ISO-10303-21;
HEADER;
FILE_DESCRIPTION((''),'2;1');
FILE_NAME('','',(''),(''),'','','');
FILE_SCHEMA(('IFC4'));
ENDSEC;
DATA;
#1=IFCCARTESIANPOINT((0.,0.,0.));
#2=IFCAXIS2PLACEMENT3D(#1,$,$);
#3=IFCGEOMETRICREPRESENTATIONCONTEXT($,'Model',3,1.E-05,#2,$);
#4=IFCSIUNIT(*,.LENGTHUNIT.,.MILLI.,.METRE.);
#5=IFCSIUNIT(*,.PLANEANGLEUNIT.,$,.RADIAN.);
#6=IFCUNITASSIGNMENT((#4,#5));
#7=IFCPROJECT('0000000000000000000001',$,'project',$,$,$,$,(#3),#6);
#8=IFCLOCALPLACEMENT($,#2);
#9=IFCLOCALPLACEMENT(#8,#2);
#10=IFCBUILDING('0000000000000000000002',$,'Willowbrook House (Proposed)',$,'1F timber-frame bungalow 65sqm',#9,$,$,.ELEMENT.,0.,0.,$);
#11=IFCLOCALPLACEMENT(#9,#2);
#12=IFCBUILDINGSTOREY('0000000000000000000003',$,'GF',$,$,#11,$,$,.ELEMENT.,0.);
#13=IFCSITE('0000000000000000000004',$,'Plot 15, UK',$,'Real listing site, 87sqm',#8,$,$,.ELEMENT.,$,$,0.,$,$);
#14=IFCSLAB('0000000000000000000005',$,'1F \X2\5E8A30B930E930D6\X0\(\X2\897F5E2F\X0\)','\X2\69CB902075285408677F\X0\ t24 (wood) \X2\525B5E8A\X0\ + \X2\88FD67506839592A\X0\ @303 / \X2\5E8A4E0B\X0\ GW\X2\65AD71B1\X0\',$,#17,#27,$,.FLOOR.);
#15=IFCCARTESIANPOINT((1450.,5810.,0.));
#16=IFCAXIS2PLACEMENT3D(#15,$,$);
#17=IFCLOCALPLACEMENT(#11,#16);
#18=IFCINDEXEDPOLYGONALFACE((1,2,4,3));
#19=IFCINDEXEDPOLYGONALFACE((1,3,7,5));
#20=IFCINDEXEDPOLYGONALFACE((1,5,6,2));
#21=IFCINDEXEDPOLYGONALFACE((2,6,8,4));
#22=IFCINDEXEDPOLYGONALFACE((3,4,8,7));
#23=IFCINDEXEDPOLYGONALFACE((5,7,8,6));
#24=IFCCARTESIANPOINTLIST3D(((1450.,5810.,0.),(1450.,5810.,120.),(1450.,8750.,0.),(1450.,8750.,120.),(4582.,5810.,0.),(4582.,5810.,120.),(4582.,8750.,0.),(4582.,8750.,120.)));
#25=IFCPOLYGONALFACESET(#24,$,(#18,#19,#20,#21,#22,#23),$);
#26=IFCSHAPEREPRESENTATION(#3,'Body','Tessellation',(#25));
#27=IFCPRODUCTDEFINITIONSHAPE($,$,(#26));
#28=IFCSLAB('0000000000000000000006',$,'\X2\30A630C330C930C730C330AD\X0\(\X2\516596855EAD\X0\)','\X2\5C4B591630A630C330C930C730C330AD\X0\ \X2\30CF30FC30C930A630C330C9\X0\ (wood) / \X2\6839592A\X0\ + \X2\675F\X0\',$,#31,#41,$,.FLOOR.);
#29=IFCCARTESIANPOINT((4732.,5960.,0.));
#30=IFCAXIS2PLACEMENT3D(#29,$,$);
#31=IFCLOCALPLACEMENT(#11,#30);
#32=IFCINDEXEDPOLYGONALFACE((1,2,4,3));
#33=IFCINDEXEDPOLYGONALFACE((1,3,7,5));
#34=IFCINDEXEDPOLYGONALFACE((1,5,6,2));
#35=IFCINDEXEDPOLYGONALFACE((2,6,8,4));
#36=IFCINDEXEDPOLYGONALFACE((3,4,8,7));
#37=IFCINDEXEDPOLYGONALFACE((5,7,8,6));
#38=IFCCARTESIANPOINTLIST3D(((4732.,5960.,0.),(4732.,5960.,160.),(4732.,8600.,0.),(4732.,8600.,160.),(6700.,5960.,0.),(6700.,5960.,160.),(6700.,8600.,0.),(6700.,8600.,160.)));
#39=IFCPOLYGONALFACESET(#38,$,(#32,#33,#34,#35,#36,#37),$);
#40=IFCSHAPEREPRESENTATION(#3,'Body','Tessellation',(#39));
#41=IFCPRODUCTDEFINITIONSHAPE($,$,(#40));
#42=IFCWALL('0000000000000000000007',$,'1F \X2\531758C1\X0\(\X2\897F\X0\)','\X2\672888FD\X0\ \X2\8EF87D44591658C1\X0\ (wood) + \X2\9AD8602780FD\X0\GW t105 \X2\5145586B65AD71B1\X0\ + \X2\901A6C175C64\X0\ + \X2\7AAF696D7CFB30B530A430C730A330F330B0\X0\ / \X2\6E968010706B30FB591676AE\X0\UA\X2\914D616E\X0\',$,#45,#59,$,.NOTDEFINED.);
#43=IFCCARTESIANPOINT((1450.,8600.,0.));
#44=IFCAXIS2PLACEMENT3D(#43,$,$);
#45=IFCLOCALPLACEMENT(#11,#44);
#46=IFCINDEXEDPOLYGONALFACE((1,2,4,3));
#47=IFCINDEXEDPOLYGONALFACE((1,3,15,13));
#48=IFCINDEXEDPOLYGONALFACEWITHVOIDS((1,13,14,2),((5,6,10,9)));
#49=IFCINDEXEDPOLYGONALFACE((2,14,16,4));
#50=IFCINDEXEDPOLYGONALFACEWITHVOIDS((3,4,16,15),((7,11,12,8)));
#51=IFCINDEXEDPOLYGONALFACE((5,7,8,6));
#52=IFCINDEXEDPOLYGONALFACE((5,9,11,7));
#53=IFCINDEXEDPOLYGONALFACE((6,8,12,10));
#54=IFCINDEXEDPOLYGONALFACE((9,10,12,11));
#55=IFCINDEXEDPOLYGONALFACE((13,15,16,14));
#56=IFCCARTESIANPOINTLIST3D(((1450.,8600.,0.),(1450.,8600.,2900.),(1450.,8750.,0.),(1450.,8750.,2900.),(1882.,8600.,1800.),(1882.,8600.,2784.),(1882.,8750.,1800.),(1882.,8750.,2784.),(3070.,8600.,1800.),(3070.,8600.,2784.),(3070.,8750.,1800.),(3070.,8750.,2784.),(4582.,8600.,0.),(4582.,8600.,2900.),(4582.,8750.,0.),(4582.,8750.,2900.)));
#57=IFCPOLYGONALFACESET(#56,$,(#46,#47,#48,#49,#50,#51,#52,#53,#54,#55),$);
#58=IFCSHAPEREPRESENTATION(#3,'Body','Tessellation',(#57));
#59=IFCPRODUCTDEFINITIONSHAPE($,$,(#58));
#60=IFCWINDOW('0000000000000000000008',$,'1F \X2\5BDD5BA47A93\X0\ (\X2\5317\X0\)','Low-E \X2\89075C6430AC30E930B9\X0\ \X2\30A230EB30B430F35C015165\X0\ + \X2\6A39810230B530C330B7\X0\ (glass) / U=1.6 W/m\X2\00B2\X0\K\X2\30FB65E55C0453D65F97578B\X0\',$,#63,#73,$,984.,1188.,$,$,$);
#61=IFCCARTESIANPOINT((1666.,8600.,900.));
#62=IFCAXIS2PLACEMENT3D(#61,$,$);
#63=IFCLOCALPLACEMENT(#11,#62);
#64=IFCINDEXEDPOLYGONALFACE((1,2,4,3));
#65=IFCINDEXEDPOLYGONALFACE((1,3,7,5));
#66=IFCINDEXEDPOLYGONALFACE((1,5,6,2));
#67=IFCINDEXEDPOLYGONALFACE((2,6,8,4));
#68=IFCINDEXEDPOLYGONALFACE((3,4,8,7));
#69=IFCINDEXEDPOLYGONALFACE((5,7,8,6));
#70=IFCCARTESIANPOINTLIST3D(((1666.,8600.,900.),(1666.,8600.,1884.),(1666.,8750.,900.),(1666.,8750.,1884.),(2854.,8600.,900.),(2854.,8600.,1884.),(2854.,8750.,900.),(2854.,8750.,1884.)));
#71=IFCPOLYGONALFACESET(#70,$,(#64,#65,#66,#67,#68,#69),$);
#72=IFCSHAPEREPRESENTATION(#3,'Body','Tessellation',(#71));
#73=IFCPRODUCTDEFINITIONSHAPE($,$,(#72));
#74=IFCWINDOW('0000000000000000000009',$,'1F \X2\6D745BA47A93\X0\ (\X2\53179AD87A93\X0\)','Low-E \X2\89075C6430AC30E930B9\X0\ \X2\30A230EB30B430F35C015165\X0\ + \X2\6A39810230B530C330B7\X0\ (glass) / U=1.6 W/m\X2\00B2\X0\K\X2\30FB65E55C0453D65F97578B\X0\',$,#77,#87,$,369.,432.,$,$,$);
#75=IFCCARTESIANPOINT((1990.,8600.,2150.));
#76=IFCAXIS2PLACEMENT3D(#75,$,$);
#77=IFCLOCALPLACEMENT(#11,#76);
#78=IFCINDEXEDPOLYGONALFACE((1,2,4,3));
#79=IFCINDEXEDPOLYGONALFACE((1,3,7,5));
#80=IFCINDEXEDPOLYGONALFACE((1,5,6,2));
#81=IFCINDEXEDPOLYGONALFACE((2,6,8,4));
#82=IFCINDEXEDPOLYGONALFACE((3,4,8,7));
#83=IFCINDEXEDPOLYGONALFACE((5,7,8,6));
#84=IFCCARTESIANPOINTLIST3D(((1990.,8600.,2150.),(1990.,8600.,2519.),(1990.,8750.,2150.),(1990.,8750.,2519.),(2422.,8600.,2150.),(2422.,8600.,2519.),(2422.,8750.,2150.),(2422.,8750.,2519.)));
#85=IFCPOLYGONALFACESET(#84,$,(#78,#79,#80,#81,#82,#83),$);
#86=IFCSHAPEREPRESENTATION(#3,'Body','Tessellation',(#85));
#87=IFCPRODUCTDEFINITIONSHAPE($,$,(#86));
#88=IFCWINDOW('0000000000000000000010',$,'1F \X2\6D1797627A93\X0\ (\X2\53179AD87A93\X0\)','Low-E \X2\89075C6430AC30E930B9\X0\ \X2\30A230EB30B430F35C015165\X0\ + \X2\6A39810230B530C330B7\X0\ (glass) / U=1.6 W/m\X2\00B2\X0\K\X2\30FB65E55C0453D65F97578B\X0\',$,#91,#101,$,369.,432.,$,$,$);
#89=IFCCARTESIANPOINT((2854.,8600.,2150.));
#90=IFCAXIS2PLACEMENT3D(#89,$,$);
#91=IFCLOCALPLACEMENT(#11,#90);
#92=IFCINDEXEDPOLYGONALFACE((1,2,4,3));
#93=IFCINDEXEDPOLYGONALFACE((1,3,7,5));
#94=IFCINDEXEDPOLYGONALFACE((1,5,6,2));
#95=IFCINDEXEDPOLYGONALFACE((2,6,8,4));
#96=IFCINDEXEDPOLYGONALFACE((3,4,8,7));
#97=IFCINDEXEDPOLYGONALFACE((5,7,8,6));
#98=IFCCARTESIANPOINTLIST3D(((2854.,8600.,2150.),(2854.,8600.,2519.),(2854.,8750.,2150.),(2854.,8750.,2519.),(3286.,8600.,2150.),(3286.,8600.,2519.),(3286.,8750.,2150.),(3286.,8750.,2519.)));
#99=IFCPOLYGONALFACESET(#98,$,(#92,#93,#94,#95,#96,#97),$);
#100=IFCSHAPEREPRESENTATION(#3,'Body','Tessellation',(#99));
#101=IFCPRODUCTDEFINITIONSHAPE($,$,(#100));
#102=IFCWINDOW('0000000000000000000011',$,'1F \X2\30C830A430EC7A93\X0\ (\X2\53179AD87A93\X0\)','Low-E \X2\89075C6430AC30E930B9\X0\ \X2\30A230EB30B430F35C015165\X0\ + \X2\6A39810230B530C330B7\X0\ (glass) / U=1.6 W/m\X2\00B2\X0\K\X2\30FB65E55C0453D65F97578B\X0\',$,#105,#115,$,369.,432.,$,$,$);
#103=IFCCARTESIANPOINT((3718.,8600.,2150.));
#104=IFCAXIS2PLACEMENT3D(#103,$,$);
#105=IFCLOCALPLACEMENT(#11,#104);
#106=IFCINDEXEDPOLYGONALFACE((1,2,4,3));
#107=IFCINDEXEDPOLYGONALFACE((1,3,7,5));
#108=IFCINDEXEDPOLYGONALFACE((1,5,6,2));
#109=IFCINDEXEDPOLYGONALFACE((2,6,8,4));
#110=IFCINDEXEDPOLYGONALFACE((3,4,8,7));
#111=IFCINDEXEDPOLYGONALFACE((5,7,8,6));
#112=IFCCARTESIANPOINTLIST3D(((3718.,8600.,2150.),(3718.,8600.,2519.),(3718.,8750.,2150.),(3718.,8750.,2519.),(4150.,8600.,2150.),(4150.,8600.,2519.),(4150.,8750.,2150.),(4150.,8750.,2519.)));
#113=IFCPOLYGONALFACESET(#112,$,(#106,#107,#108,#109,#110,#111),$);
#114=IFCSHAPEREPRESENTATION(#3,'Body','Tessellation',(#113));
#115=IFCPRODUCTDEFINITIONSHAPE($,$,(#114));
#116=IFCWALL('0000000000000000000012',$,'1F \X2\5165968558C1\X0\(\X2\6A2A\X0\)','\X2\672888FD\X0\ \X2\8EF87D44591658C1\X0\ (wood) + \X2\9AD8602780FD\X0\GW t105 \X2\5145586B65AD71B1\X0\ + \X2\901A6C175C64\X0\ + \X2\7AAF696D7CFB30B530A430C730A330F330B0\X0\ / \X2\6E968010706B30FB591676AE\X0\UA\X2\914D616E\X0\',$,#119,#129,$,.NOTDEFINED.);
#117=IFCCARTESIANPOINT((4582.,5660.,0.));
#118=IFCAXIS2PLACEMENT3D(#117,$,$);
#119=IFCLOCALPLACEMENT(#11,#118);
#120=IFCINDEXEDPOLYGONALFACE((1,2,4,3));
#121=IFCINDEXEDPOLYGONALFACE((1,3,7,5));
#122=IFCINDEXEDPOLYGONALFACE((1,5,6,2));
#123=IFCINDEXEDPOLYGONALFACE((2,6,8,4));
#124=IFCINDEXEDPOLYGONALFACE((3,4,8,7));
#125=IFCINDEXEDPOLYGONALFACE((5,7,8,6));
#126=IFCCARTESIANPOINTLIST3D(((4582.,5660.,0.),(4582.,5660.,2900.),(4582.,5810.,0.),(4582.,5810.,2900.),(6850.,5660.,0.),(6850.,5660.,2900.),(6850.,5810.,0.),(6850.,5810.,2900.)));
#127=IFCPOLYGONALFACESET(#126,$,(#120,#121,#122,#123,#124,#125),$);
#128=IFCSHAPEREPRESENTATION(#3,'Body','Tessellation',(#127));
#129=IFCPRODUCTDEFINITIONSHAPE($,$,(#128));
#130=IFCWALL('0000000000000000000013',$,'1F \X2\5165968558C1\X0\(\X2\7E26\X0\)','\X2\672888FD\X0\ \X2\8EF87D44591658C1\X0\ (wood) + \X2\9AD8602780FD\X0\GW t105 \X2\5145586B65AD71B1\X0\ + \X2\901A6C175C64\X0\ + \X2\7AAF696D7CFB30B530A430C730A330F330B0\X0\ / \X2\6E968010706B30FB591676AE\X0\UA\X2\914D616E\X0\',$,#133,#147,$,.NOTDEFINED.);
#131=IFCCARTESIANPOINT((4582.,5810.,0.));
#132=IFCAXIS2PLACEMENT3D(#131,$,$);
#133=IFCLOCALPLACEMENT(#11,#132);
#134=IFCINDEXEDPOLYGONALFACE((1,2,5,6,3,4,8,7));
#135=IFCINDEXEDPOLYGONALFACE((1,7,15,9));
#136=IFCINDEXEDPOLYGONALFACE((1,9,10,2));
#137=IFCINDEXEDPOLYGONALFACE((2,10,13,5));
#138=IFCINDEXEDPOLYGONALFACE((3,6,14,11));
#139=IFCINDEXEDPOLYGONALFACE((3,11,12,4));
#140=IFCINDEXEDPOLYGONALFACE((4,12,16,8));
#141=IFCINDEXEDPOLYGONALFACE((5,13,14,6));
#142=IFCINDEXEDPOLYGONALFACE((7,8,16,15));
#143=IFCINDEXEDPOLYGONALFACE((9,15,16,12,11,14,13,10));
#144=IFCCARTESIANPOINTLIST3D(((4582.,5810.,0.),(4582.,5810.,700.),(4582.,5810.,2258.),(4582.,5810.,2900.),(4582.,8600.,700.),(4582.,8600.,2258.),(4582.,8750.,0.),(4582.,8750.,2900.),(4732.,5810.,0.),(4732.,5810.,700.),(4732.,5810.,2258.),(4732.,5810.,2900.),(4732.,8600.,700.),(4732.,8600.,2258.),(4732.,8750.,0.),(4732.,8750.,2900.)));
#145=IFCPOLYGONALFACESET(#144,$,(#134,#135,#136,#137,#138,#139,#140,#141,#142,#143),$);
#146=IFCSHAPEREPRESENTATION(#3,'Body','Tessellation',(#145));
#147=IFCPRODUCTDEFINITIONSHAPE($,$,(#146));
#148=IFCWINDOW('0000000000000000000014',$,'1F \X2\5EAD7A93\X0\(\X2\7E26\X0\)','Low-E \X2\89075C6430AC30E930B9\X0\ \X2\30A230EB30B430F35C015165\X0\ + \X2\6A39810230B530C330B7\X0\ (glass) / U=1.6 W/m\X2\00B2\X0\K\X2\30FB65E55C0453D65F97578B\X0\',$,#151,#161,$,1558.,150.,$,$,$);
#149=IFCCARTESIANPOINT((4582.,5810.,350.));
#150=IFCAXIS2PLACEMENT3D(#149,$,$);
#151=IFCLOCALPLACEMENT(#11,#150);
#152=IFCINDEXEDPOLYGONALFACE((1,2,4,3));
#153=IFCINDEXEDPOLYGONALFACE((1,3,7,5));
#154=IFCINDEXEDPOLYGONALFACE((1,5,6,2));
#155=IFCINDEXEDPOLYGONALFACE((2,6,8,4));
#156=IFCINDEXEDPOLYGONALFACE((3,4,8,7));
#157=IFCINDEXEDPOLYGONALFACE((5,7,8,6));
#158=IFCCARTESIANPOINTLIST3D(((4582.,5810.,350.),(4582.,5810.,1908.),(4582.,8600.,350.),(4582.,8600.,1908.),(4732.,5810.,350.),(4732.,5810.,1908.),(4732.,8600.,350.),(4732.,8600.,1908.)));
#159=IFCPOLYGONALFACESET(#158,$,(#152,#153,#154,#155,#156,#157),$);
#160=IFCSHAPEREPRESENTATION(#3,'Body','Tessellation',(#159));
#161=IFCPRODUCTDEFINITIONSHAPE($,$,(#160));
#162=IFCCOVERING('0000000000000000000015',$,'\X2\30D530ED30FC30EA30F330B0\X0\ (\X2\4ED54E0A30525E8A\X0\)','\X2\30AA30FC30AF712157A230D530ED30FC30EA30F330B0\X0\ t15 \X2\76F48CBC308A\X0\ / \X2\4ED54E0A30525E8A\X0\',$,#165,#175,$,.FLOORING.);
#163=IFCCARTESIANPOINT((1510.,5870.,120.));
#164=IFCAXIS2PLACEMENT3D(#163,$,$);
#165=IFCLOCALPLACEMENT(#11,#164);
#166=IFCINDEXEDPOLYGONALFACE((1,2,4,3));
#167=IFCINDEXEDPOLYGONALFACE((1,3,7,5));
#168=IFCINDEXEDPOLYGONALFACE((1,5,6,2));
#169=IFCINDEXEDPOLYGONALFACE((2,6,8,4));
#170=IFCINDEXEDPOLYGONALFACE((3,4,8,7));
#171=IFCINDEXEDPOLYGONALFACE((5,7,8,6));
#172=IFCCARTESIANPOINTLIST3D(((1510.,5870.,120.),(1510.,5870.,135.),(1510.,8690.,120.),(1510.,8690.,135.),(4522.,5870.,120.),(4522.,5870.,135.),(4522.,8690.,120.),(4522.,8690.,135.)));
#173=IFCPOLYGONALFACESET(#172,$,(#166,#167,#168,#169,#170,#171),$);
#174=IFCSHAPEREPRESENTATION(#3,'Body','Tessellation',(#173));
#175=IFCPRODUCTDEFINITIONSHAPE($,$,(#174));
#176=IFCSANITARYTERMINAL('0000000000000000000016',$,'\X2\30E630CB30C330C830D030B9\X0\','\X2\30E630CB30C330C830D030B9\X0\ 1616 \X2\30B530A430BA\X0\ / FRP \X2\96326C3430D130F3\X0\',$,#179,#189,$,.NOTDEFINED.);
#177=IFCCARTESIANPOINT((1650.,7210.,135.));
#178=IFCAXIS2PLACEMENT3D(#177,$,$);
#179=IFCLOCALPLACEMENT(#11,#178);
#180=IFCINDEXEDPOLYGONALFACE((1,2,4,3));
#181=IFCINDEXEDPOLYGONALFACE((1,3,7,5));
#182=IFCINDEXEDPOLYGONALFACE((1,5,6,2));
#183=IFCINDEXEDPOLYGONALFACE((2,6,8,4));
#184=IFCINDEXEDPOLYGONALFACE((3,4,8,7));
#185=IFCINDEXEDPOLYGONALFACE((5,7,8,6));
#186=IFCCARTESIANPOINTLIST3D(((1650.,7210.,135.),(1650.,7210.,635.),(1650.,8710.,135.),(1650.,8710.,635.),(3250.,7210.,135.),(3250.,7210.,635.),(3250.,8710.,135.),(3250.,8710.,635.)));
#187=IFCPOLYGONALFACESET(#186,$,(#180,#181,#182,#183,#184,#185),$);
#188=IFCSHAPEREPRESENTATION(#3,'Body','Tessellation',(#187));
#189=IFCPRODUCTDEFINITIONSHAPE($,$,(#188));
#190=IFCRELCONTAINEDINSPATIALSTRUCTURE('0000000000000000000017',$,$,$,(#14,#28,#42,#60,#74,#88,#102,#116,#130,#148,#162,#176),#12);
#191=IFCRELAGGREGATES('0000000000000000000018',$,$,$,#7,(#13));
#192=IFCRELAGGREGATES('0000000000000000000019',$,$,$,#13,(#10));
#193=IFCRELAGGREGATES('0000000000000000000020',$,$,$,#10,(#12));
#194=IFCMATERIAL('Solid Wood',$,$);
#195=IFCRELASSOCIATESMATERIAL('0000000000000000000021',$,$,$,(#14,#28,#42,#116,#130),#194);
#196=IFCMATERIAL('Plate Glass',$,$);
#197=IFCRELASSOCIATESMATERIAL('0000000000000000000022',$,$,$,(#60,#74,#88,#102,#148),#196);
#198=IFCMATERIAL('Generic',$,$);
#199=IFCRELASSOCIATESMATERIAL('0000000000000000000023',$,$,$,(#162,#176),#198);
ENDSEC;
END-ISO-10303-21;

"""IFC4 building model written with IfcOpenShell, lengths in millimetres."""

from ifc_helpers import new_model, si_unit, frame, frame_2d, origin, place, context, project, spatial, rectangle, extrude, material, element, fill, save


model = new_model("IFC4")

# Units and contexts
model_context = context("Model", 3, precision=1e-05, world=origin())
ifc_project = project(units=[si_unit("LENGTHUNIT", "METRE", prefix="MILLI"), si_unit("PLANEANGLEUNIT", "RADIAN")], contexts=[model_context])

# Site, building, storey
site_placement = place(None, origin())
site = spatial("IfcSite", under=ifc_project, at=site_placement, Name="Plot 15, UK", ObjectType="Real listing site, 87sqm", CompositionType="ELEMENT", RefElevation=0.0)
building_placement = place(site_placement, origin())
building = spatial("IfcBuilding", under=site, at=building_placement, Name="Willowbrook House (Proposed)", ObjectType="1F timber-frame bungalow 65sqm", CompositionType="ELEMENT", ElevationOfRefHeight=0.0, ElevationOfTerrain=0.0)
storey_placement = place(building_placement, origin())
storey = spatial("IfcBuildingStorey", under=building, at=storey_placement, Name="GF", CompositionType="ELEMENT", Elevation=0.0)

# Slabs
ifc_material_1 = material(Name="Solid Wood")
slab_1_placement = place(storey_placement, frame((1450.0, 5810.0, 0.0)))
element("IfcSlab", 1, at=slab_1_placement, inside=storey, material=ifc_material_1, Name="1F 床スラブ(西帯)", Description="構造用合板 t24 (wood) 剛床 + 製材根太 @303 / 床下 GW断熱", PredefinedType="FLOOR", context=model_context, shape_type="SweptSolid", body=[
    extrude(rectangle(XDim=3132.0, YDim=2940.0, at=frame_2d((1566.0, 1470.0))), frame((1450.0, 5810.0, 0.0)), (0.0, 0.0, 1.0), 120.0),
])
slab_2_placement = place(storey_placement, frame((4732.0, 5960.0, 0.0)))
element("IfcSlab", 2, at=slab_2_placement, inside=storey, material=ifc_material_1, Name="ウッドデッキ(入隅庭)", Description="屋外ウッドデッキ ハードウッド (wood) / 根太 + 束", PredefinedType="FLOOR", context=model_context, shape_type="SweptSolid", body=[
    extrude(rectangle(XDim=1968.0, YDim=2640.0, at=frame_2d((984.0, 1320.0))), frame((4732.0, 5960.0, 0.0)), (0.0, 0.0, 1.0), 160.0),
])

# Wall, openings, windows
wall_1_placement = place(storey_placement, frame((1450.0, 8600.0, 0.0)))
wall_1 = element("IfcWall", 3, at=wall_1_placement, inside=storey, material=ifc_material_1, Name="1F 北壁(西)", Description="木製 軸組外壁 (wood) + 高性能GW t105 充填断熱 + 通気層 + 窯業系サイディング / 準耐火・外皮UA配慮", PredefinedType="NOTDEFINED", context=model_context, shape_type="SweptSolid", body=[
    extrude(rectangle(XDim=3132.0, YDim=150.0, at=frame_2d((1566.0, 75.0))), frame((1450.0, 8600.0, 0.0)), (0.0, 0.0, 1.0), 2900.0),
])
opening_1_placement = place(storey_placement, frame((1666.0, 8600.0, 900.0)))
opening_1 = element("IfcOpeningElement", 4, at=opening_1_placement, cuts=wall_1, PredefinedType="NOTDEFINED", context=model_context, shape_type="SweptSolid", body=[
    extrude(rectangle(XDim=1188.0, YDim=150.0, at=frame_2d((594.0, 75.0))), frame((1666.0, 8600.0, 900.0)), (0.0, 0.0, 1.0), 984.0),
])
opening_2_placement = place(storey_placement, frame((1990.0, 8600.0, 2150.0)))
opening_2 = element("IfcOpeningElement", 5, at=opening_2_placement, cuts=wall_1, PredefinedType="NOTDEFINED", context=model_context, shape_type="SweptSolid", body=[
    extrude(rectangle(XDim=432.0, YDim=150.0, at=frame_2d((216.0, 75.0))), frame((1990.0, 8600.0, 2150.0)), (0.0, 0.0, 1.0), 369.0),
])
opening_3_placement = place(storey_placement, frame((2854.0, 8600.0, 2150.0)))
opening_3 = element("IfcOpeningElement", 6, at=opening_3_placement, cuts=wall_1, PredefinedType="NOTDEFINED", context=model_context, shape_type="SweptSolid", body=[
    extrude(rectangle(XDim=432.0, YDim=150.0, at=frame_2d((216.0, 75.0))), frame((2854.0, 8600.0, 2150.0)), (0.0, 0.0, 1.0), 369.0),
])
opening_4_placement = place(storey_placement, frame((3718.0, 8600.0, 2150.0)))
opening_4 = element("IfcOpeningElement", 7, at=opening_4_placement, cuts=wall_1, PredefinedType="NOTDEFINED", context=model_context, shape_type="SweptSolid", body=[
    extrude(rectangle(XDim=432.0, YDim=150.0, at=frame_2d((216.0, 75.0))), frame((3718.0, 8600.0, 2150.0)), (0.0, 0.0, 1.0), 369.0),
])
ifc_material_2 = material(Name="Plate Glass")
window_1_placement = place(storey_placement, frame((1666.0, 8600.0, 900.0)))
window_1 = element("IfcWindow", 8, at=window_1_placement, inside=storey, material=ifc_material_2, Name="1F 寝室窓 (北)", Description="Low-E 複層ガラス アルゴン封入 + 樹脂サッシ (glass) / U=1.6 W/m²K・日射取得型", OverallHeight=984.0, OverallWidth=1188.0, context=model_context, shape_type="SweptSolid", body=[
    extrude(rectangle(XDim=1188.0, YDim=150.0, at=frame_2d((594.0, 75.0))), frame((1666.0, 8600.0, 900.0)), (0.0, 0.0, 1.0), 984.0),
])
fill(opening_1, window_1)
window_2_placement = place(storey_placement, frame((1990.0, 8600.0, 2150.0)))
window_2 = element("IfcWindow", 9, at=window_2_placement, inside=storey, material=ifc_material_2, Name="1F 浴室窓 (北高窓)", Description="Low-E 複層ガラス アルゴン封入 + 樹脂サッシ (glass) / U=1.6 W/m²K・日射取得型", OverallHeight=369.0, OverallWidth=432.0, context=model_context, shape_type="SweptSolid", body=[
    extrude(rectangle(XDim=432.0, YDim=150.0, at=frame_2d((216.0, 75.0))), frame((1990.0, 8600.0, 2150.0)), (0.0, 0.0, 1.0), 369.0),
])
fill(opening_2, window_2)
window_3_placement = place(storey_placement, frame((2854.0, 8600.0, 2150.0)))
window_3 = element("IfcWindow", 10, at=window_3_placement, inside=storey, material=ifc_material_2, Name="1F 洗面窓 (北高窓)", Description="Low-E 複層ガラス アルゴン封入 + 樹脂サッシ (glass) / U=1.6 W/m²K・日射取得型", OverallHeight=369.0, OverallWidth=432.0, context=model_context, shape_type="SweptSolid", body=[
    extrude(rectangle(XDim=432.0, YDim=150.0, at=frame_2d((216.0, 75.0))), frame((2854.0, 8600.0, 2150.0)), (0.0, 0.0, 1.0), 369.0),
])
fill(opening_3, window_3)
window_4_placement = place(storey_placement, frame((3718.0, 8600.0, 2150.0)))
window_4 = element("IfcWindow", 11, at=window_4_placement, inside=storey, material=ifc_material_2, Name="1F トイレ窓 (北高窓)", Description="Low-E 複層ガラス アルゴン封入 + 樹脂サッシ (glass) / U=1.6 W/m²K・日射取得型", OverallHeight=369.0, OverallWidth=432.0, context=model_context, shape_type="SweptSolid", body=[
    extrude(rectangle(XDim=432.0, YDim=150.0, at=frame_2d((216.0, 75.0))), frame((3718.0, 8600.0, 2150.0)), (0.0, 0.0, 1.0), 369.0),
])
fill(opening_4, window_4)

# Wall
wall_2_placement = place(storey_placement, frame((4582.0, 5660.0, 0.0)))
element("IfcWall", 12, at=wall_2_placement, inside=storey, material=ifc_material_1, Name="1F 入隅壁(横)", Description="木製 軸組外壁 (wood) + 高性能GW t105 充填断熱 + 通気層 + 窯業系サイディング / 準耐火・外皮UA配慮", PredefinedType="NOTDEFINED", context=model_context, shape_type="SweptSolid", body=[
    extrude(rectangle(XDim=2268.0, YDim=150.0, at=frame_2d((1134.0, 75.0))), frame((4582.0, 5660.0, 0.0)), (0.0, 0.0, 1.0), 2900.0),
])

# Wall, opening, window
wall_3_placement = place(storey_placement, frame((4582.0, 5810.0, 0.0)))
wall_3 = element("IfcWall", 13, at=wall_3_placement, inside=storey, material=ifc_material_1, Name="1F 入隅壁(縦)", Description="木製 軸組外壁 (wood) + 高性能GW t105 充填断熱 + 通気層 + 窯業系サイディング / 準耐火・外皮UA配慮", PredefinedType="NOTDEFINED", context=model_context, shape_type="SweptSolid", body=[
    extrude(rectangle(XDim=150.0, YDim=2940.0, at=frame_2d((75.0, 1470.0))), frame((4582.0, 5810.0, 0.0)), (0.0, 0.0, 1.0), 2900.0),
])
opening_5_placement = place(storey_placement, frame((4582.0, 5810.0, 350.0)))
opening_5 = element("IfcOpeningElement", 14, at=opening_5_placement, cuts=wall_3, PredefinedType="NOTDEFINED", context=model_context, shape_type="SweptSolid", body=[
    extrude(rectangle(XDim=150.0, YDim=2790.0, at=frame_2d((75.0, 1395.0))), frame((4582.0, 5810.0, 350.0)), (0.0, 0.0, 1.0), 1558.0),
])
window_5_placement = place(storey_placement, frame((4582.0, 5810.0, 350.0)))
window_5 = element("IfcWindow", 15, at=window_5_placement, inside=storey, material=ifc_material_2, Name="1F 庭窓(縦)", Description="Low-E 複層ガラス アルゴン封入 + 樹脂サッシ (glass) / U=1.6 W/m²K・日射取得型", OverallHeight=1558.0, OverallWidth=150.0, context=model_context, shape_type="SweptSolid", body=[
    extrude(rectangle(XDim=150.0, YDim=2790.0, at=frame_2d((75.0, 1395.0))), frame((4582.0, 5810.0, 350.0)), (0.0, 0.0, 1.0), 1558.0),
])
fill(opening_5, window_5)

# Covering
ifc_material_3 = material(Name="Generic")
covering_placement = place(storey_placement, frame((1510.0, 5870.0, 120.0)))
element("IfcCovering", 16, at=covering_placement, inside=storey, material=ifc_material_3, Name="フローリング (仕上げ床)", Description="オーク無垢フローリング t15 直貼り / 仕上げ床", PredefinedType="FLOORING", context=model_context, shape_type="SweptSolid", body=[
    extrude(rectangle(XDim=3012.0, YDim=2820.0, at=frame_2d((1506.0, 1410.0))), frame((1510.0, 5870.0, 120.0)), (0.0, 0.0, 1.0), 15.0),
])

# Sanitary terminal
sanitary_terminal_1_placement = place(storey_placement, frame((1650.0, 7210.0, 135.0)))
element("IfcSanitaryTerminal", 17, at=sanitary_terminal_1_placement, inside=storey, material=ifc_material_3, Name="ユニットバス", Description="ユニットバス 1616 サイズ / FRP 防水パン", PredefinedType="NOTDEFINED", context=model_context, shape_type="SweptSolid", body=[
    extrude(rectangle(XDim=1600.0, YDim=1500.0, at=frame_2d((800.0, 750.0))), frame((1650.0, 7210.0, 135.0)), (0.0, 0.0, 1.0), 500.0),
])

save(model, "model.ifc")
